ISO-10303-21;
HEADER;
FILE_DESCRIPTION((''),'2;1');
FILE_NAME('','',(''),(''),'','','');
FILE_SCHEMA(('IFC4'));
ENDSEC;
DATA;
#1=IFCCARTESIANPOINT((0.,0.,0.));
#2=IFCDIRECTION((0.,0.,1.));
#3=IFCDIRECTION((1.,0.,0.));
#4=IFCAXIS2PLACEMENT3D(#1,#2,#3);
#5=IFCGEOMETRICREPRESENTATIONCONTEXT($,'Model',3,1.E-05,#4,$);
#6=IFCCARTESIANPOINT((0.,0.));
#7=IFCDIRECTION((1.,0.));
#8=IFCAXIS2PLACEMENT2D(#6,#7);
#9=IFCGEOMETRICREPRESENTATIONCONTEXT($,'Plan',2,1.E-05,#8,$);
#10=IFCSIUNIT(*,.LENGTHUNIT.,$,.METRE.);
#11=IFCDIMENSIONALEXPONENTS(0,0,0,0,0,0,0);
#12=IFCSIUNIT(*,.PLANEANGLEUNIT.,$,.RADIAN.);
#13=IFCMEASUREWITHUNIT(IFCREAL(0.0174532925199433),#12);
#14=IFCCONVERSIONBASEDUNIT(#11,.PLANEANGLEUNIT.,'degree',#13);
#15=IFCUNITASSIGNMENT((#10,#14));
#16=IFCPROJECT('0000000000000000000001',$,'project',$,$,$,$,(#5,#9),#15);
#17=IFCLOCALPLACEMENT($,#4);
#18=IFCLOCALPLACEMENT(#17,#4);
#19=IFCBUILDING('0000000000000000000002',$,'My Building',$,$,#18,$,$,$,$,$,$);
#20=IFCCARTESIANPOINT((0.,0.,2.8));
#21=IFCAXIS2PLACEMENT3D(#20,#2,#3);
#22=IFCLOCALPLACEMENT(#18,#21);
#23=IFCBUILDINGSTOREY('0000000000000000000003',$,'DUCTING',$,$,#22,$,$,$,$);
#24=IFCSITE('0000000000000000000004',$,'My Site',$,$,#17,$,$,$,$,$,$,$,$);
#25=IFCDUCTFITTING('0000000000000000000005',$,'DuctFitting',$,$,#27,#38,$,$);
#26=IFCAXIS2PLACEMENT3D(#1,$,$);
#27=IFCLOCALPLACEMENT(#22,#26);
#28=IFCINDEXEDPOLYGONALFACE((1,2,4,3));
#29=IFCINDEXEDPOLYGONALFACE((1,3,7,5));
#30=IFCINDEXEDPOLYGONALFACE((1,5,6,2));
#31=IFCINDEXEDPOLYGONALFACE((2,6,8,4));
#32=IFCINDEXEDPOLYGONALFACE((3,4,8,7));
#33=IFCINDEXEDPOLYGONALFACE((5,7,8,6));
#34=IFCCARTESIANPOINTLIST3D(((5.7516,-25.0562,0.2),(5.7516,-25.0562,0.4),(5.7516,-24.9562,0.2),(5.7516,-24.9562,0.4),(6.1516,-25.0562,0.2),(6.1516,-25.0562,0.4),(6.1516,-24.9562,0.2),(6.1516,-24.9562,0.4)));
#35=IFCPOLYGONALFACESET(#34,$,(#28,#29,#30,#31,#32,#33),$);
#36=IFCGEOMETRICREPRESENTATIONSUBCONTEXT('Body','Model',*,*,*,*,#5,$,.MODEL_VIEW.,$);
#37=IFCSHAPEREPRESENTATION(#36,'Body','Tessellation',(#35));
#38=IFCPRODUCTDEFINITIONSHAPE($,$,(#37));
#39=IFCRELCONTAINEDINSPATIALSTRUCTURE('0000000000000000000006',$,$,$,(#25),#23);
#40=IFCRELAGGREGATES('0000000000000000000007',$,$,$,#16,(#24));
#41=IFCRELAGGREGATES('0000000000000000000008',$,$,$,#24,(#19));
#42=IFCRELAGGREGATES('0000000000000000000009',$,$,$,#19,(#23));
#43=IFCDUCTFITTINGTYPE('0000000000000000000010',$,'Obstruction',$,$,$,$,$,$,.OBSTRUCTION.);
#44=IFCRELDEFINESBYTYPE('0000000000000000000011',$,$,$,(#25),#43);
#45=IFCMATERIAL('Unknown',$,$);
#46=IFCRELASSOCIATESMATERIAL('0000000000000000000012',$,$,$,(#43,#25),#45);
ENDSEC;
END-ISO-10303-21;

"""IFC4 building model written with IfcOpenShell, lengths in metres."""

from ifc_helpers import new_model, entity, si_unit, converted_unit, frame, origin_with_axes, origin_2d_with_axis, place, context, subcontext, project, spatial, rectangle, extrude, material, material_profile, profile_set, profile_usage, type_object, element, save


model = new_model("IFC4")

# Units and contexts
model_context = context("Model", 3, precision=1e-05, world=origin_with_axes())
plan_context = context("Plan", 2, precision=1e-05, world=origin_2d_with_axis())
body_context = subcontext(model_context, "Body", "Model", "MODEL_VIEW")
ifc_project = project(units=[si_unit("LENGTHUNIT", "METRE"), converted_unit("PLANEANGLEUNIT", "degree", entity("IfcReal", 0.0174532925199433), si_unit("PLANEANGLEUNIT", "RADIAN"), dimensions=[0, 0, 0, 0, 0, 0, 0])], contexts=[model_context, plan_context])

# Site, building, storey
site_placement = place(None, origin_with_axes())
site = spatial("IfcSite", under=ifc_project, at=site_placement, Name="My Site")
building_placement = place(site_placement, origin_with_axes())
building = spatial("IfcBuilding", under=site, at=building_placement, Name="My Building")
storey_placement = place(building_placement, frame((0.0, 0.0, 2.8), z_axis=(0.0, 0.0, 1.0), x_axis=(1.0, 0.0, 0.0)))
storey = spatial("IfcBuildingStorey", under=building, at=storey_placement, Name="DUCTING")

# Shared definitions
ifc_material = material(Name="Unknown")

# Duct fitting
ifc_material_profile_1 = material_profile(ifc_material, rectangle(XDim=0.4, YDim=0.2))
ifc_profile_set_1 = profile_set([ifc_material_profile_1])
duct_fitting_type_1 = type_object("IfcDuctFittingType", Name="Obstruction", PredefinedType="OBSTRUCTION", material=ifc_profile_set_1)
ifc_profile_usage_1 = profile_usage(ifc_profile_set_1, cardinal=5)
duct_fitting_1_placement = place(storey_placement, frame((5.9516, -24.9562, 0.3), z_axis=(0.0, -1.0, 0.0), x_axis=(1.0, 0.0, 0.0)))
element("IfcDuctFitting", 1, at=duct_fitting_1_placement, inside=storey, type_object=duct_fitting_type_1, material=ifc_profile_usage_1, Name="DuctFitting", context=body_context, shape_type="SweptSolid", body=[
    extrude(rectangle(XDim=0.4, YDim=0.2), origin_with_axes(), (0.0, 0.0, 1.0), 0.1),
])

save(model, "model.ifc")
